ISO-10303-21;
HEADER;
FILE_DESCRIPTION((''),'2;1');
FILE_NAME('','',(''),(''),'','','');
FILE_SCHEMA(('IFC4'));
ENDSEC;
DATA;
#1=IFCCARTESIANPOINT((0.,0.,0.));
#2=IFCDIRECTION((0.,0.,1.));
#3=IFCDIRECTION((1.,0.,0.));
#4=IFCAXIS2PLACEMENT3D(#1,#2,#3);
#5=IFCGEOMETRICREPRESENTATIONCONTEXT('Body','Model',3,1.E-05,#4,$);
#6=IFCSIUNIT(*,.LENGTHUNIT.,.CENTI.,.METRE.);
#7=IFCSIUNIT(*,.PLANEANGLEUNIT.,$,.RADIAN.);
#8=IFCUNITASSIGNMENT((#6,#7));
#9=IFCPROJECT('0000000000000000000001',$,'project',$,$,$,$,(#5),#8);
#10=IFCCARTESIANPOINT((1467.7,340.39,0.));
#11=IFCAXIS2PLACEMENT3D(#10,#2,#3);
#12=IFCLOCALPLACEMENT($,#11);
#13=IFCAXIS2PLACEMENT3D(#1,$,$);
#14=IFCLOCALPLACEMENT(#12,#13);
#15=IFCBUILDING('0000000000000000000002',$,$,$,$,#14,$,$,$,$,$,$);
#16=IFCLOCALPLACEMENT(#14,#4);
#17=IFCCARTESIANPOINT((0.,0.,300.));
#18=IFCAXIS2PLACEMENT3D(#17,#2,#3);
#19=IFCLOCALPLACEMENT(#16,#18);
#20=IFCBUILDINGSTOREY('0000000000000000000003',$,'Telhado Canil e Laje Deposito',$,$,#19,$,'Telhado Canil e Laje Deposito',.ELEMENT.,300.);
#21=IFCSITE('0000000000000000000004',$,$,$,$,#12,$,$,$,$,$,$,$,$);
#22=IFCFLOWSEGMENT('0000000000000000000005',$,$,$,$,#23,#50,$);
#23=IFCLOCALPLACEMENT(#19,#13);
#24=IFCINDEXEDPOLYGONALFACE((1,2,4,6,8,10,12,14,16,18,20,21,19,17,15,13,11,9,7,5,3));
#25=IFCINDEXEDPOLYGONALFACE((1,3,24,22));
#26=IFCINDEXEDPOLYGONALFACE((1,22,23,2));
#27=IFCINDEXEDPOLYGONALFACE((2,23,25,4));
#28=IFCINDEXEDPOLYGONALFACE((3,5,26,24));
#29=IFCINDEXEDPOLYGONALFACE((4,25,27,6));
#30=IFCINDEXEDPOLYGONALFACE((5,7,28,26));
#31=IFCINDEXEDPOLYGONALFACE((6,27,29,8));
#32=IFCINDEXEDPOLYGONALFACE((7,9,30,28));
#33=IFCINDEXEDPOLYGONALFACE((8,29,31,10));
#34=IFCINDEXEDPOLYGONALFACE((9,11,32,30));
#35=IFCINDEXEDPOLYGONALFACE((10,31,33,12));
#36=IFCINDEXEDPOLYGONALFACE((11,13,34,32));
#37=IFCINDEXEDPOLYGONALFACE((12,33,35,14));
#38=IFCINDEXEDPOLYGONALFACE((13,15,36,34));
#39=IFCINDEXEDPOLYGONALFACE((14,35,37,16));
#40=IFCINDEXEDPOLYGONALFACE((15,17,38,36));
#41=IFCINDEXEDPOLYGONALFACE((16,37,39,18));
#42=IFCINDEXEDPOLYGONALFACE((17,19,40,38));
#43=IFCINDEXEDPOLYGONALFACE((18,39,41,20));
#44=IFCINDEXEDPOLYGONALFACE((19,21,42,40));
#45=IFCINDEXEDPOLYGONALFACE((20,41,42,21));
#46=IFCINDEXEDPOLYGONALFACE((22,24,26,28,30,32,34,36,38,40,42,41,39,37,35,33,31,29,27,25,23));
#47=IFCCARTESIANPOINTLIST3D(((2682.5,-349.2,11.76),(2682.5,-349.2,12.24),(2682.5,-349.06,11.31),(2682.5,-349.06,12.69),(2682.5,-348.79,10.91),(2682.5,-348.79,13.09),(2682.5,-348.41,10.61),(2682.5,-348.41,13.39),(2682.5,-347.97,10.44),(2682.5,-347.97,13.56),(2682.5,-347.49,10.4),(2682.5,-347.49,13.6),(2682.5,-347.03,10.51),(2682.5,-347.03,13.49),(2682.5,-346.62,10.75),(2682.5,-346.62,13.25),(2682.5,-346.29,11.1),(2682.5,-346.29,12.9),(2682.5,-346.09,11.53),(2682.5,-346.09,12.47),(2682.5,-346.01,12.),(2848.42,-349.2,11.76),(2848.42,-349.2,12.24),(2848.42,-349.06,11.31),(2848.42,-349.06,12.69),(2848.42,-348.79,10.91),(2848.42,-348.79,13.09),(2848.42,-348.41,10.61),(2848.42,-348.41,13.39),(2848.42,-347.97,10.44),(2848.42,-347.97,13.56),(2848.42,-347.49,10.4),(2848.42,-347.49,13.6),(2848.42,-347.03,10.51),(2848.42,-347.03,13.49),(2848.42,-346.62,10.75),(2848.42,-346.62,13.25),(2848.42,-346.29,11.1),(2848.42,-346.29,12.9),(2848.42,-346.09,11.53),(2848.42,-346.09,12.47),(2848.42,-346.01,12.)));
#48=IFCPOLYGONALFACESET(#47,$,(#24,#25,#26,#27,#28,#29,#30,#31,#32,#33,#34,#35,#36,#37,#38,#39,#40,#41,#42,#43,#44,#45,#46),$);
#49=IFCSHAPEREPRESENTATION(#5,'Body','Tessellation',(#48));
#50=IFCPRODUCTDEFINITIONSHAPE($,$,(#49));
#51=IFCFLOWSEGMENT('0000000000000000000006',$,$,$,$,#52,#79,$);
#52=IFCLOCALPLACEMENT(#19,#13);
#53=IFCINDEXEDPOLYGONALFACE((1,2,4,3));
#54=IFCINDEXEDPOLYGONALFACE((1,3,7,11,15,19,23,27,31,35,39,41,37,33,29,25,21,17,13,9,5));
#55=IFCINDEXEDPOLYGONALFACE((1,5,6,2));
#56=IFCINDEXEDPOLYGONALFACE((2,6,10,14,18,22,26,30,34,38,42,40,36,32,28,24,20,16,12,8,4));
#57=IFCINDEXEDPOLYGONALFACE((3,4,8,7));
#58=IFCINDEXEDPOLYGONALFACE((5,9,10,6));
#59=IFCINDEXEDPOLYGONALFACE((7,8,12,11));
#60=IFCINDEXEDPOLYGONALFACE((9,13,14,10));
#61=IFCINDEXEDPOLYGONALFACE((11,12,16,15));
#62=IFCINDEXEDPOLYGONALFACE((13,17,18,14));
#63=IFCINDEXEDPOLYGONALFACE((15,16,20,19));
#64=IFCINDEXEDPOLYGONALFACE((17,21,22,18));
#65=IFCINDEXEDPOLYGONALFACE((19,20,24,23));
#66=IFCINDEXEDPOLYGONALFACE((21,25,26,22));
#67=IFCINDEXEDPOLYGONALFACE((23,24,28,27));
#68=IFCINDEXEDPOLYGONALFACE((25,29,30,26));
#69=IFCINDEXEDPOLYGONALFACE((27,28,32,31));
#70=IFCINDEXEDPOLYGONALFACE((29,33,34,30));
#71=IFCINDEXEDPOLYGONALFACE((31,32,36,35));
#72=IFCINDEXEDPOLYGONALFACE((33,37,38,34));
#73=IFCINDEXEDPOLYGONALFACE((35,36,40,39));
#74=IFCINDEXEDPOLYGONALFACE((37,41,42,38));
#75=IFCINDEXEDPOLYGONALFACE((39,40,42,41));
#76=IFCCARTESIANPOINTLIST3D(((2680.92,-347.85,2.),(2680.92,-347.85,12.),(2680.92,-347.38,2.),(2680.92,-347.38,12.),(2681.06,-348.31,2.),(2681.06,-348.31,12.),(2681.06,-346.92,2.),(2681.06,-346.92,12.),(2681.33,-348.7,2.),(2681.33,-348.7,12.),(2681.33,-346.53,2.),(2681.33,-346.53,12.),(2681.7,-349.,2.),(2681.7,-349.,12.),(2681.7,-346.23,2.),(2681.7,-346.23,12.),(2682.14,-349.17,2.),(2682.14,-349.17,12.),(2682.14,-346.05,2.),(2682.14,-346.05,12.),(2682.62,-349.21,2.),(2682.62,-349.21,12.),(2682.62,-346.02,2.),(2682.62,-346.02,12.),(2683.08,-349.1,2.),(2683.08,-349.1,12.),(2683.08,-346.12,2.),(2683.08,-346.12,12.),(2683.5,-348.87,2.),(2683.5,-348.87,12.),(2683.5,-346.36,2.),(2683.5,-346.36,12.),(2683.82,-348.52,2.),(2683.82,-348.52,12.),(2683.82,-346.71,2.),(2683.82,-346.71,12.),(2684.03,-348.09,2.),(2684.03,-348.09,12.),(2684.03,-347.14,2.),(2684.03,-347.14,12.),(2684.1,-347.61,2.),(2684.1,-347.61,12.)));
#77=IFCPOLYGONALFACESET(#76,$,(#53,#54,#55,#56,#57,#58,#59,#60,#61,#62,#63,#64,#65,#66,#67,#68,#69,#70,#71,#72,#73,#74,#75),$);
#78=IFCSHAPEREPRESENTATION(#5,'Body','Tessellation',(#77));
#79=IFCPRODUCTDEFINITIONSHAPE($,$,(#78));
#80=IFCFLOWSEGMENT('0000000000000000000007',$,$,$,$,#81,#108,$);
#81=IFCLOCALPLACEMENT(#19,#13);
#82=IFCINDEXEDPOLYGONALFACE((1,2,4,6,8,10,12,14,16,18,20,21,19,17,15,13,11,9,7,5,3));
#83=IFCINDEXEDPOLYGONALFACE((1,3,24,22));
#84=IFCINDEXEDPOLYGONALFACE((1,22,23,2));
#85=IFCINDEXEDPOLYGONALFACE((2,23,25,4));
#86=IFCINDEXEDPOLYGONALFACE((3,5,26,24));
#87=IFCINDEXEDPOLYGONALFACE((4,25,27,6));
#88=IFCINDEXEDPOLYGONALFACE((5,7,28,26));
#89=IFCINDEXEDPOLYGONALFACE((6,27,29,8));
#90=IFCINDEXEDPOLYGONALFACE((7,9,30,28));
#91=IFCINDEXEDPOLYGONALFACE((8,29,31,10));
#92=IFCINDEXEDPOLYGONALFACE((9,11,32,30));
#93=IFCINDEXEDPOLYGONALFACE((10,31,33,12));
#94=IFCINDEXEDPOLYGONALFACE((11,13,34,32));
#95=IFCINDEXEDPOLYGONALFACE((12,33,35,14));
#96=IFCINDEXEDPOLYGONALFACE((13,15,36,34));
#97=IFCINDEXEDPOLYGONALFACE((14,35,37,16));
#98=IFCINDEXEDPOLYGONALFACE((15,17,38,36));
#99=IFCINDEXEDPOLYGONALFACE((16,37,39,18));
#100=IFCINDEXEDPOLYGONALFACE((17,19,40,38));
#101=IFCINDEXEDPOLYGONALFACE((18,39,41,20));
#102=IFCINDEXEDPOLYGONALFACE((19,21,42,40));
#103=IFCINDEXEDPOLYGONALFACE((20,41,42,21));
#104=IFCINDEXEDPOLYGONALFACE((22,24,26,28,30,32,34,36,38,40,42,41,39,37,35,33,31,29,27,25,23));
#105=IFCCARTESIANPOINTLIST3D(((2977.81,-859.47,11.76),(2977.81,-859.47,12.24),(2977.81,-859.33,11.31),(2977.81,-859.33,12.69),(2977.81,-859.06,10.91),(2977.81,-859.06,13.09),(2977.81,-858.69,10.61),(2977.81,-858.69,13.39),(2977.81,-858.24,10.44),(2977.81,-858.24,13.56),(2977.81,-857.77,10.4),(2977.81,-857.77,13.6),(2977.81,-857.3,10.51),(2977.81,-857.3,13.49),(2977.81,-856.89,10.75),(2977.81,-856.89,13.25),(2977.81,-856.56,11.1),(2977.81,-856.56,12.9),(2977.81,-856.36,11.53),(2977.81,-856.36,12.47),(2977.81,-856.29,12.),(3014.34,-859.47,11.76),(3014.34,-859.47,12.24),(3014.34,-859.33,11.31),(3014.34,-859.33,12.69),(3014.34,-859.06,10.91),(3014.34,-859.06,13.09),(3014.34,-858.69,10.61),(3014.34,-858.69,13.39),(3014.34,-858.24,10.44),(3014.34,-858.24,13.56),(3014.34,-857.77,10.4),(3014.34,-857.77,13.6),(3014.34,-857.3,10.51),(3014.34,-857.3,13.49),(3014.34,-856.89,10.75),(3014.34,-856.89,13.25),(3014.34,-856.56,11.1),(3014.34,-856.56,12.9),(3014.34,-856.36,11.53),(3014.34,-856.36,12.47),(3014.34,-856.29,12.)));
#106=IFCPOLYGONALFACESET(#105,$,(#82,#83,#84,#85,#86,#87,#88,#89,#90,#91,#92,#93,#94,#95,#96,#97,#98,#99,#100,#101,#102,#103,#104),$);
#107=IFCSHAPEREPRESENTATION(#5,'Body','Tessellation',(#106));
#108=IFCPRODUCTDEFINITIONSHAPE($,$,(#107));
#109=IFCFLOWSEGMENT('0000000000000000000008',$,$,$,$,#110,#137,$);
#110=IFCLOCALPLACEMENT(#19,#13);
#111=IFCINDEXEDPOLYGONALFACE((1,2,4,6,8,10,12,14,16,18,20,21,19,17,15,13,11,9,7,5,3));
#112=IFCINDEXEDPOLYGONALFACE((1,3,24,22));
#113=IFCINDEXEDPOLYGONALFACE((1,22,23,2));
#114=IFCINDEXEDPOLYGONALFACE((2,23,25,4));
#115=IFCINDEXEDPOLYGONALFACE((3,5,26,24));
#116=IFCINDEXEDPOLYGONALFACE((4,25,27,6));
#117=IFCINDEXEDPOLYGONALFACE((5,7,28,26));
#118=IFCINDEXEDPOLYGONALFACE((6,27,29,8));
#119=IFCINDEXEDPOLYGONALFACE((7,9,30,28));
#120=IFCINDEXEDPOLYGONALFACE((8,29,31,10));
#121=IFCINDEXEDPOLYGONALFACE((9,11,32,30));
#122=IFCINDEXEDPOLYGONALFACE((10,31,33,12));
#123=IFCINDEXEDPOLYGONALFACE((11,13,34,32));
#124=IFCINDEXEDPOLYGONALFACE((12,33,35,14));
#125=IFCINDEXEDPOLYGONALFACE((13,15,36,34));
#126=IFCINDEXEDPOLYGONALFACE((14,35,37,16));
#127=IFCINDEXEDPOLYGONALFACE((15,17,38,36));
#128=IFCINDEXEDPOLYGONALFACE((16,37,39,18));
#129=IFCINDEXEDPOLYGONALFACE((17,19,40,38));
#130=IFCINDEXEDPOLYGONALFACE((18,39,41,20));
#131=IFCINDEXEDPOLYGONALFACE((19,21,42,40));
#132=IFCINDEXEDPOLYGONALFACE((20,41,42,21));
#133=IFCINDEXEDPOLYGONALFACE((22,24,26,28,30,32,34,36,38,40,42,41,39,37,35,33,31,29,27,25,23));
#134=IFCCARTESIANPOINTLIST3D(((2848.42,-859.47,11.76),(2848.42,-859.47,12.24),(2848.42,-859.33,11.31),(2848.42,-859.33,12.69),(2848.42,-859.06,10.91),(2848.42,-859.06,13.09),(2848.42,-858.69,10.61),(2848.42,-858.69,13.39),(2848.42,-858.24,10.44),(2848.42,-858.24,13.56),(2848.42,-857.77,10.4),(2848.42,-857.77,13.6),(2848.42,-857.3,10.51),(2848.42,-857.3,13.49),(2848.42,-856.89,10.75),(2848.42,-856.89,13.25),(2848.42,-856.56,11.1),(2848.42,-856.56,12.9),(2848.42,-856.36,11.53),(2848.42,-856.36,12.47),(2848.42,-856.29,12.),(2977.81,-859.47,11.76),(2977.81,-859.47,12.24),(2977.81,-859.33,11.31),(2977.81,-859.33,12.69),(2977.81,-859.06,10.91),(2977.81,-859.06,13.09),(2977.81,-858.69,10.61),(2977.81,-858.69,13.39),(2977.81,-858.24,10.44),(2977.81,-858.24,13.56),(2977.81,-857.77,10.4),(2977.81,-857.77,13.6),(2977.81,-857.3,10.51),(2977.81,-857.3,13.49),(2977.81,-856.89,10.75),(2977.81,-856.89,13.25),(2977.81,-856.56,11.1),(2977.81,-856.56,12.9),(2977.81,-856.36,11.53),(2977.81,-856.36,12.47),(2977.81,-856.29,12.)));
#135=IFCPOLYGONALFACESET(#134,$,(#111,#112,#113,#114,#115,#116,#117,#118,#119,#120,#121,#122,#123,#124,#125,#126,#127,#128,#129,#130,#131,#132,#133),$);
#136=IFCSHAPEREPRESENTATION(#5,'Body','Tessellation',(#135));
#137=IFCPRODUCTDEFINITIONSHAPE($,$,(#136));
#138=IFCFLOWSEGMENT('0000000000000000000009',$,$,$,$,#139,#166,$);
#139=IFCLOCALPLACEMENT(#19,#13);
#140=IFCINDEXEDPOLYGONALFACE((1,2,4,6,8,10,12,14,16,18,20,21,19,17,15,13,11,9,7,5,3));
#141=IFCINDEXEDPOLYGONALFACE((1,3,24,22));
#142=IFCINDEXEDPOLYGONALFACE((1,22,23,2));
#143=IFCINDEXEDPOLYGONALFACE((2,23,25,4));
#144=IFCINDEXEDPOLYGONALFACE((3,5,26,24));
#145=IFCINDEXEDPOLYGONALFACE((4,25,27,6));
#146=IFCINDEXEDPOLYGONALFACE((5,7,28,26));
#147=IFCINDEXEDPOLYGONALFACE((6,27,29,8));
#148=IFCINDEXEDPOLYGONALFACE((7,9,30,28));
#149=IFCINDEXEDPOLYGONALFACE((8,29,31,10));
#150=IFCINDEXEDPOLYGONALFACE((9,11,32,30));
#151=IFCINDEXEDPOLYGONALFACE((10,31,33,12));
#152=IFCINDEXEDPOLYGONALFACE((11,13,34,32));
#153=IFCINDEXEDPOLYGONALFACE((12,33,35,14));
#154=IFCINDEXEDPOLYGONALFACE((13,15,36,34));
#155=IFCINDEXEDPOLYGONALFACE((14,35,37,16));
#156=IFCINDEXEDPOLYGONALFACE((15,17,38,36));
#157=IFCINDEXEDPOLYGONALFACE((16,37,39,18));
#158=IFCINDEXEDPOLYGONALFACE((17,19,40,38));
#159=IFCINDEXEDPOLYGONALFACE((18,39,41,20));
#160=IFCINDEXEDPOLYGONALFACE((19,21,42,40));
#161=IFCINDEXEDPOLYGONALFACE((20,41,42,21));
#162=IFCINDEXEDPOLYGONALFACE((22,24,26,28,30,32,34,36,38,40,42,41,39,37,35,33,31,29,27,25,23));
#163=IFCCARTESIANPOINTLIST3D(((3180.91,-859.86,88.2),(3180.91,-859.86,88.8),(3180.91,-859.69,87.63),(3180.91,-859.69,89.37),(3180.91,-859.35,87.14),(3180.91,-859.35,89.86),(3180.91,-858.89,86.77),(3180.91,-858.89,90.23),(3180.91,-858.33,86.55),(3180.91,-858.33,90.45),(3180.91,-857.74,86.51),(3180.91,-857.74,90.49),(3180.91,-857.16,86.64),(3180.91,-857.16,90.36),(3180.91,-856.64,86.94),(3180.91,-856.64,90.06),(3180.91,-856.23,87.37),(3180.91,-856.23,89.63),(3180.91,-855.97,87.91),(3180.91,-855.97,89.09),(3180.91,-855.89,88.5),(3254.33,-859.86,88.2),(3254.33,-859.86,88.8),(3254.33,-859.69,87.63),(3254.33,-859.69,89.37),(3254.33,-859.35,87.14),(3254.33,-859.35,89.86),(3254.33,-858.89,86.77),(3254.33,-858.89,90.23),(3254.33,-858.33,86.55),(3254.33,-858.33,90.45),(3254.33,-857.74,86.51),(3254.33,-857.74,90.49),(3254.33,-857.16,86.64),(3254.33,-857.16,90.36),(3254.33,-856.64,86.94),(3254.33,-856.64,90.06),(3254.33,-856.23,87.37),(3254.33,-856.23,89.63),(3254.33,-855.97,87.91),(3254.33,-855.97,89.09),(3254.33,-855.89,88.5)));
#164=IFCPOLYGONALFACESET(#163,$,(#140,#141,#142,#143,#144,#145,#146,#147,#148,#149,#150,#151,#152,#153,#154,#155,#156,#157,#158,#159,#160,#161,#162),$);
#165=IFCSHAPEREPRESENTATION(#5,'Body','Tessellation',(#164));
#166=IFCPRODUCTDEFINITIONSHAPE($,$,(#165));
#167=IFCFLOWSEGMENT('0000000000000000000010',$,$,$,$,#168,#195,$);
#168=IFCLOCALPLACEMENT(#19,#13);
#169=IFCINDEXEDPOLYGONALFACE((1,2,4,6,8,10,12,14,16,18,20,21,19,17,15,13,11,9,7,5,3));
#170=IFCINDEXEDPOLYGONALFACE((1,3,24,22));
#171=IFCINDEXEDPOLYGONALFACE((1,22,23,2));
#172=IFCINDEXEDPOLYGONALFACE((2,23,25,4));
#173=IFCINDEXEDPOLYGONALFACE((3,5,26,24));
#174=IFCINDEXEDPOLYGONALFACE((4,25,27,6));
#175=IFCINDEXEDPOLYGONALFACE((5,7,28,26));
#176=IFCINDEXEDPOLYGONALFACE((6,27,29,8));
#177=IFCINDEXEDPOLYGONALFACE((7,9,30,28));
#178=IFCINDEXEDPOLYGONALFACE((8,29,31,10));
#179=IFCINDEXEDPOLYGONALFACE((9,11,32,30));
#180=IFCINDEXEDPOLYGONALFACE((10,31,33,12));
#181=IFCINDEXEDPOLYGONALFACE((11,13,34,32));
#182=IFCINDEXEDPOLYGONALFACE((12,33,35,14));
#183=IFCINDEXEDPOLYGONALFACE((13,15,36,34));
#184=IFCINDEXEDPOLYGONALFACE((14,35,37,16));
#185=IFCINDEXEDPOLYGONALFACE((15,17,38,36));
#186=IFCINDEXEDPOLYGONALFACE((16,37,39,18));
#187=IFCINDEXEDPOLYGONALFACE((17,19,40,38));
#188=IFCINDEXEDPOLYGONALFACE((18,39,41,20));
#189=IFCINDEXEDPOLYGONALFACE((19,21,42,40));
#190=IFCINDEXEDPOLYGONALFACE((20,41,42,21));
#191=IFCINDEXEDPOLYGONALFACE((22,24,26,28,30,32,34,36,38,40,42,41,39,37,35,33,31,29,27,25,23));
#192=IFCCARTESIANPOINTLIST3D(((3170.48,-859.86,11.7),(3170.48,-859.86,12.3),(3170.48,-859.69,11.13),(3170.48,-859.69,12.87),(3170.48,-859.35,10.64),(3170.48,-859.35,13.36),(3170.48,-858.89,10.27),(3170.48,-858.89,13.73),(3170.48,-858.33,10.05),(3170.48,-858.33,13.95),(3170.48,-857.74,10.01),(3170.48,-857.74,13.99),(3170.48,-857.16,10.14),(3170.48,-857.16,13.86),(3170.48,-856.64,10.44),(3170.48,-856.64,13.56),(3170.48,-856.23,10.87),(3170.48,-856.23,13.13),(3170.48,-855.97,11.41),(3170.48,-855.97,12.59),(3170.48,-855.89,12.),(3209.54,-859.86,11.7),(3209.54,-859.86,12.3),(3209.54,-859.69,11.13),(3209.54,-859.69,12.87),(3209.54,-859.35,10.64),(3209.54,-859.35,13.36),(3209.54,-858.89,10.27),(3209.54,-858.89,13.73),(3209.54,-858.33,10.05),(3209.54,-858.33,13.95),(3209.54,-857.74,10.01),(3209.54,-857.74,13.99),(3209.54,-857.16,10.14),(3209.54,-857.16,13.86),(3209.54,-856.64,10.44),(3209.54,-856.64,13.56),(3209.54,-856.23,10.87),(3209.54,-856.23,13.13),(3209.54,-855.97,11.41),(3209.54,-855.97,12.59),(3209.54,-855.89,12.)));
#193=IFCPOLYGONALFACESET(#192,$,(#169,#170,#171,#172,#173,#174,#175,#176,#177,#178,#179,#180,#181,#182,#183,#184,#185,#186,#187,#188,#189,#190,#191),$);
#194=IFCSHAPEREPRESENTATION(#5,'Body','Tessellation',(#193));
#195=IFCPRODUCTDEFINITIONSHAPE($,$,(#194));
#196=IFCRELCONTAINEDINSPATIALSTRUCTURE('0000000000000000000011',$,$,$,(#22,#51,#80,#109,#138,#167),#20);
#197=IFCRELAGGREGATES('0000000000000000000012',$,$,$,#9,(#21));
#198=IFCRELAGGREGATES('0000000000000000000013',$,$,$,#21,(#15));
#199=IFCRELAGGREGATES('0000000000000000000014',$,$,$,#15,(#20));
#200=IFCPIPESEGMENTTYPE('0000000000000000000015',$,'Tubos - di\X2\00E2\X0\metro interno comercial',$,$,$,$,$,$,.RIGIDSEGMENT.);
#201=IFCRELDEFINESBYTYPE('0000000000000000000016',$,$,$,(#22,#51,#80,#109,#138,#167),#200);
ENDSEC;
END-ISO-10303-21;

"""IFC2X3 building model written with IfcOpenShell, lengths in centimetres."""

from ifc_helpers import new_model, si_unit, frame, origin, origin_with_axes, origin_2d_with_axis, place, context, project, spatial, circle, extrude, type_object, element, save


model = new_model("IFC2X3")

# Units and contexts
model_context = context("Model", 3, precision=1e-05, world=origin_with_axes(), identifier="Body")
ifc_project = project(units=[si_unit("LENGTHUNIT", "METRE", prefix="CENTI"), si_unit("PLANEANGLEUNIT", "RADIAN")], contexts=[model_context])

# Site, building, storey
site_placement = place(None, frame((1467.7, 340.39, 0.0), z_axis=(0.0, 0.0, 1.0), x_axis=(1.0, 0.0, 0.0)))
site = spatial("IfcSite", under=ifc_project, at=site_placement)
building_placement = place(site_placement, origin())
building = spatial("IfcBuilding", under=site, at=building_placement)
placement = place(building_placement, origin_with_axes())
storey_placement = place(placement, frame((0.0, 0.0, 300.0), z_axis=(0.0, 0.0, 1.0), x_axis=(1.0, 0.0, 0.0)))
storey = spatial("IfcBuildingStorey", under=building, at=storey_placement, Name="Telhado Canil e Laje Deposito", LongName="Telhado Canil e Laje Deposito", CompositionType="ELEMENT", Elevation=300.0)

# Flow segments
pipe_segment_type_1 = type_object("IfcPipeSegmentType", Name="Tubos - diâmetro interno comercial", PredefinedType="RIGIDSEGMENT")
flow_segment_1_placement = place(storey_placement, frame((2765.46, -347.61, 13.6), z_axis=(0.0, 0.0, 1.0), x_axis=(1.0, 0.0, 0.0)))
element("IfcFlowSegment", 1, at=flow_segment_1_placement, inside=storey, type_object=pipe_segment_type_1, context=model_context, shape_type="SolidModel", body=[
    extrude(circle(Radius=1.6, at=origin_2d_with_axis()), frame((82.96, 0.0, -1.6), z_axis=(-1.0, 0.0, 0.0), x_axis=(0.0, 1.0, 0.0)), (0.0, 0.0, 1.0), 165.92),
])
flow_segment_2_placement = place(storey_placement, frame((2682.5, -347.61, 12.0), z_axis=(0.0, 0.0, 1.0), x_axis=(1.0, 0.0, 0.0)))
element("IfcFlowSegment", 2, at=flow_segment_2_placement, inside=storey, type_object=pipe_segment_type_1, context=model_context, shape_type="SolidModel", body=[
    extrude(circle(Radius=1.6, at=origin_2d_with_axis()), frame((0.0, 0.0, 0.0), z_axis=(0.0, 0.0, -1.0), x_axis=(1.0, 0.0, 0.0)), (0.0, 0.0, 1.0), 10.0),
])
flow_segment_3_placement = place(storey_placement, frame((2996.07, -857.89, 13.6), z_axis=(0.0, 0.0, 1.0), x_axis=(1.0, 0.0, 0.0)))
element("IfcFlowSegment", 3, at=flow_segment_3_placement, inside=storey, type_object=pipe_segment_type_1, context=model_context, shape_type="SolidModel", body=[
    extrude(circle(Radius=1.6, at=origin_2d_with_axis()), frame((18.27, 0.0, -1.6), z_axis=(-1.0, 0.0, 0.0), x_axis=(0.0, 1.0, 0.0)), (0.0, 0.0, 1.0), 36.53),
])
flow_segment_4_placement = place(storey_placement, frame((2913.11, -857.89, 13.6), z_axis=(0.0, 0.0, 1.0), x_axis=(1.0, 0.0, 0.0)))
element("IfcFlowSegment", 4, at=flow_segment_4_placement, inside=storey, type_object=pipe_segment_type_1, context=model_context, shape_type="SolidModel", body=[
    extrude(circle(Radius=1.6, at=origin_2d_with_axis()), frame((64.69, 0.0, -1.6), z_axis=(-1.0, 0.0, 0.0), x_axis=(0.0, 1.0, 0.0)), (0.0, 0.0, 1.0), 129.39),
])
flow_segment_5_placement = place(storey_placement, frame((3217.62, -857.89, 90.5), z_axis=(0.0, 0.0, 1.0), x_axis=(1.0, 0.0, 0.0)))
element("IfcFlowSegment", 5, at=flow_segment_5_placement, inside=storey, type_object=pipe_segment_type_1, context=model_context, shape_type="SolidModel", body=[
    extrude(circle(Radius=2.0, at=origin_2d_with_axis()), frame((-36.71, 0.0, -2.0), z_axis=(1.0, 0.0, 0.0), x_axis=(0.0, 1.0, 0.0)), (0.0, 0.0, 1.0), 73.42),
])
flow_segment_6_placement = place(storey_placement, frame((3190.01, -857.89, 14.0), z_axis=(0.0, 0.0, 1.0), x_axis=(1.0, 0.0, 0.0)))
element("IfcFlowSegment", 6, at=flow_segment_6_placement, inside=storey, type_object=pipe_segment_type_1, context=model_context, shape_type="SolidModel", body=[
    extrude(circle(Radius=2.0, at=origin_2d_with_axis()), frame((-19.53, 0.0, -2.0), z_axis=(1.0, 0.0, 0.0), x_axis=(0.0, 1.0, 0.0)), (0.0, 0.0, 1.0), 39.06),
])

save(model, "model.ifc")
